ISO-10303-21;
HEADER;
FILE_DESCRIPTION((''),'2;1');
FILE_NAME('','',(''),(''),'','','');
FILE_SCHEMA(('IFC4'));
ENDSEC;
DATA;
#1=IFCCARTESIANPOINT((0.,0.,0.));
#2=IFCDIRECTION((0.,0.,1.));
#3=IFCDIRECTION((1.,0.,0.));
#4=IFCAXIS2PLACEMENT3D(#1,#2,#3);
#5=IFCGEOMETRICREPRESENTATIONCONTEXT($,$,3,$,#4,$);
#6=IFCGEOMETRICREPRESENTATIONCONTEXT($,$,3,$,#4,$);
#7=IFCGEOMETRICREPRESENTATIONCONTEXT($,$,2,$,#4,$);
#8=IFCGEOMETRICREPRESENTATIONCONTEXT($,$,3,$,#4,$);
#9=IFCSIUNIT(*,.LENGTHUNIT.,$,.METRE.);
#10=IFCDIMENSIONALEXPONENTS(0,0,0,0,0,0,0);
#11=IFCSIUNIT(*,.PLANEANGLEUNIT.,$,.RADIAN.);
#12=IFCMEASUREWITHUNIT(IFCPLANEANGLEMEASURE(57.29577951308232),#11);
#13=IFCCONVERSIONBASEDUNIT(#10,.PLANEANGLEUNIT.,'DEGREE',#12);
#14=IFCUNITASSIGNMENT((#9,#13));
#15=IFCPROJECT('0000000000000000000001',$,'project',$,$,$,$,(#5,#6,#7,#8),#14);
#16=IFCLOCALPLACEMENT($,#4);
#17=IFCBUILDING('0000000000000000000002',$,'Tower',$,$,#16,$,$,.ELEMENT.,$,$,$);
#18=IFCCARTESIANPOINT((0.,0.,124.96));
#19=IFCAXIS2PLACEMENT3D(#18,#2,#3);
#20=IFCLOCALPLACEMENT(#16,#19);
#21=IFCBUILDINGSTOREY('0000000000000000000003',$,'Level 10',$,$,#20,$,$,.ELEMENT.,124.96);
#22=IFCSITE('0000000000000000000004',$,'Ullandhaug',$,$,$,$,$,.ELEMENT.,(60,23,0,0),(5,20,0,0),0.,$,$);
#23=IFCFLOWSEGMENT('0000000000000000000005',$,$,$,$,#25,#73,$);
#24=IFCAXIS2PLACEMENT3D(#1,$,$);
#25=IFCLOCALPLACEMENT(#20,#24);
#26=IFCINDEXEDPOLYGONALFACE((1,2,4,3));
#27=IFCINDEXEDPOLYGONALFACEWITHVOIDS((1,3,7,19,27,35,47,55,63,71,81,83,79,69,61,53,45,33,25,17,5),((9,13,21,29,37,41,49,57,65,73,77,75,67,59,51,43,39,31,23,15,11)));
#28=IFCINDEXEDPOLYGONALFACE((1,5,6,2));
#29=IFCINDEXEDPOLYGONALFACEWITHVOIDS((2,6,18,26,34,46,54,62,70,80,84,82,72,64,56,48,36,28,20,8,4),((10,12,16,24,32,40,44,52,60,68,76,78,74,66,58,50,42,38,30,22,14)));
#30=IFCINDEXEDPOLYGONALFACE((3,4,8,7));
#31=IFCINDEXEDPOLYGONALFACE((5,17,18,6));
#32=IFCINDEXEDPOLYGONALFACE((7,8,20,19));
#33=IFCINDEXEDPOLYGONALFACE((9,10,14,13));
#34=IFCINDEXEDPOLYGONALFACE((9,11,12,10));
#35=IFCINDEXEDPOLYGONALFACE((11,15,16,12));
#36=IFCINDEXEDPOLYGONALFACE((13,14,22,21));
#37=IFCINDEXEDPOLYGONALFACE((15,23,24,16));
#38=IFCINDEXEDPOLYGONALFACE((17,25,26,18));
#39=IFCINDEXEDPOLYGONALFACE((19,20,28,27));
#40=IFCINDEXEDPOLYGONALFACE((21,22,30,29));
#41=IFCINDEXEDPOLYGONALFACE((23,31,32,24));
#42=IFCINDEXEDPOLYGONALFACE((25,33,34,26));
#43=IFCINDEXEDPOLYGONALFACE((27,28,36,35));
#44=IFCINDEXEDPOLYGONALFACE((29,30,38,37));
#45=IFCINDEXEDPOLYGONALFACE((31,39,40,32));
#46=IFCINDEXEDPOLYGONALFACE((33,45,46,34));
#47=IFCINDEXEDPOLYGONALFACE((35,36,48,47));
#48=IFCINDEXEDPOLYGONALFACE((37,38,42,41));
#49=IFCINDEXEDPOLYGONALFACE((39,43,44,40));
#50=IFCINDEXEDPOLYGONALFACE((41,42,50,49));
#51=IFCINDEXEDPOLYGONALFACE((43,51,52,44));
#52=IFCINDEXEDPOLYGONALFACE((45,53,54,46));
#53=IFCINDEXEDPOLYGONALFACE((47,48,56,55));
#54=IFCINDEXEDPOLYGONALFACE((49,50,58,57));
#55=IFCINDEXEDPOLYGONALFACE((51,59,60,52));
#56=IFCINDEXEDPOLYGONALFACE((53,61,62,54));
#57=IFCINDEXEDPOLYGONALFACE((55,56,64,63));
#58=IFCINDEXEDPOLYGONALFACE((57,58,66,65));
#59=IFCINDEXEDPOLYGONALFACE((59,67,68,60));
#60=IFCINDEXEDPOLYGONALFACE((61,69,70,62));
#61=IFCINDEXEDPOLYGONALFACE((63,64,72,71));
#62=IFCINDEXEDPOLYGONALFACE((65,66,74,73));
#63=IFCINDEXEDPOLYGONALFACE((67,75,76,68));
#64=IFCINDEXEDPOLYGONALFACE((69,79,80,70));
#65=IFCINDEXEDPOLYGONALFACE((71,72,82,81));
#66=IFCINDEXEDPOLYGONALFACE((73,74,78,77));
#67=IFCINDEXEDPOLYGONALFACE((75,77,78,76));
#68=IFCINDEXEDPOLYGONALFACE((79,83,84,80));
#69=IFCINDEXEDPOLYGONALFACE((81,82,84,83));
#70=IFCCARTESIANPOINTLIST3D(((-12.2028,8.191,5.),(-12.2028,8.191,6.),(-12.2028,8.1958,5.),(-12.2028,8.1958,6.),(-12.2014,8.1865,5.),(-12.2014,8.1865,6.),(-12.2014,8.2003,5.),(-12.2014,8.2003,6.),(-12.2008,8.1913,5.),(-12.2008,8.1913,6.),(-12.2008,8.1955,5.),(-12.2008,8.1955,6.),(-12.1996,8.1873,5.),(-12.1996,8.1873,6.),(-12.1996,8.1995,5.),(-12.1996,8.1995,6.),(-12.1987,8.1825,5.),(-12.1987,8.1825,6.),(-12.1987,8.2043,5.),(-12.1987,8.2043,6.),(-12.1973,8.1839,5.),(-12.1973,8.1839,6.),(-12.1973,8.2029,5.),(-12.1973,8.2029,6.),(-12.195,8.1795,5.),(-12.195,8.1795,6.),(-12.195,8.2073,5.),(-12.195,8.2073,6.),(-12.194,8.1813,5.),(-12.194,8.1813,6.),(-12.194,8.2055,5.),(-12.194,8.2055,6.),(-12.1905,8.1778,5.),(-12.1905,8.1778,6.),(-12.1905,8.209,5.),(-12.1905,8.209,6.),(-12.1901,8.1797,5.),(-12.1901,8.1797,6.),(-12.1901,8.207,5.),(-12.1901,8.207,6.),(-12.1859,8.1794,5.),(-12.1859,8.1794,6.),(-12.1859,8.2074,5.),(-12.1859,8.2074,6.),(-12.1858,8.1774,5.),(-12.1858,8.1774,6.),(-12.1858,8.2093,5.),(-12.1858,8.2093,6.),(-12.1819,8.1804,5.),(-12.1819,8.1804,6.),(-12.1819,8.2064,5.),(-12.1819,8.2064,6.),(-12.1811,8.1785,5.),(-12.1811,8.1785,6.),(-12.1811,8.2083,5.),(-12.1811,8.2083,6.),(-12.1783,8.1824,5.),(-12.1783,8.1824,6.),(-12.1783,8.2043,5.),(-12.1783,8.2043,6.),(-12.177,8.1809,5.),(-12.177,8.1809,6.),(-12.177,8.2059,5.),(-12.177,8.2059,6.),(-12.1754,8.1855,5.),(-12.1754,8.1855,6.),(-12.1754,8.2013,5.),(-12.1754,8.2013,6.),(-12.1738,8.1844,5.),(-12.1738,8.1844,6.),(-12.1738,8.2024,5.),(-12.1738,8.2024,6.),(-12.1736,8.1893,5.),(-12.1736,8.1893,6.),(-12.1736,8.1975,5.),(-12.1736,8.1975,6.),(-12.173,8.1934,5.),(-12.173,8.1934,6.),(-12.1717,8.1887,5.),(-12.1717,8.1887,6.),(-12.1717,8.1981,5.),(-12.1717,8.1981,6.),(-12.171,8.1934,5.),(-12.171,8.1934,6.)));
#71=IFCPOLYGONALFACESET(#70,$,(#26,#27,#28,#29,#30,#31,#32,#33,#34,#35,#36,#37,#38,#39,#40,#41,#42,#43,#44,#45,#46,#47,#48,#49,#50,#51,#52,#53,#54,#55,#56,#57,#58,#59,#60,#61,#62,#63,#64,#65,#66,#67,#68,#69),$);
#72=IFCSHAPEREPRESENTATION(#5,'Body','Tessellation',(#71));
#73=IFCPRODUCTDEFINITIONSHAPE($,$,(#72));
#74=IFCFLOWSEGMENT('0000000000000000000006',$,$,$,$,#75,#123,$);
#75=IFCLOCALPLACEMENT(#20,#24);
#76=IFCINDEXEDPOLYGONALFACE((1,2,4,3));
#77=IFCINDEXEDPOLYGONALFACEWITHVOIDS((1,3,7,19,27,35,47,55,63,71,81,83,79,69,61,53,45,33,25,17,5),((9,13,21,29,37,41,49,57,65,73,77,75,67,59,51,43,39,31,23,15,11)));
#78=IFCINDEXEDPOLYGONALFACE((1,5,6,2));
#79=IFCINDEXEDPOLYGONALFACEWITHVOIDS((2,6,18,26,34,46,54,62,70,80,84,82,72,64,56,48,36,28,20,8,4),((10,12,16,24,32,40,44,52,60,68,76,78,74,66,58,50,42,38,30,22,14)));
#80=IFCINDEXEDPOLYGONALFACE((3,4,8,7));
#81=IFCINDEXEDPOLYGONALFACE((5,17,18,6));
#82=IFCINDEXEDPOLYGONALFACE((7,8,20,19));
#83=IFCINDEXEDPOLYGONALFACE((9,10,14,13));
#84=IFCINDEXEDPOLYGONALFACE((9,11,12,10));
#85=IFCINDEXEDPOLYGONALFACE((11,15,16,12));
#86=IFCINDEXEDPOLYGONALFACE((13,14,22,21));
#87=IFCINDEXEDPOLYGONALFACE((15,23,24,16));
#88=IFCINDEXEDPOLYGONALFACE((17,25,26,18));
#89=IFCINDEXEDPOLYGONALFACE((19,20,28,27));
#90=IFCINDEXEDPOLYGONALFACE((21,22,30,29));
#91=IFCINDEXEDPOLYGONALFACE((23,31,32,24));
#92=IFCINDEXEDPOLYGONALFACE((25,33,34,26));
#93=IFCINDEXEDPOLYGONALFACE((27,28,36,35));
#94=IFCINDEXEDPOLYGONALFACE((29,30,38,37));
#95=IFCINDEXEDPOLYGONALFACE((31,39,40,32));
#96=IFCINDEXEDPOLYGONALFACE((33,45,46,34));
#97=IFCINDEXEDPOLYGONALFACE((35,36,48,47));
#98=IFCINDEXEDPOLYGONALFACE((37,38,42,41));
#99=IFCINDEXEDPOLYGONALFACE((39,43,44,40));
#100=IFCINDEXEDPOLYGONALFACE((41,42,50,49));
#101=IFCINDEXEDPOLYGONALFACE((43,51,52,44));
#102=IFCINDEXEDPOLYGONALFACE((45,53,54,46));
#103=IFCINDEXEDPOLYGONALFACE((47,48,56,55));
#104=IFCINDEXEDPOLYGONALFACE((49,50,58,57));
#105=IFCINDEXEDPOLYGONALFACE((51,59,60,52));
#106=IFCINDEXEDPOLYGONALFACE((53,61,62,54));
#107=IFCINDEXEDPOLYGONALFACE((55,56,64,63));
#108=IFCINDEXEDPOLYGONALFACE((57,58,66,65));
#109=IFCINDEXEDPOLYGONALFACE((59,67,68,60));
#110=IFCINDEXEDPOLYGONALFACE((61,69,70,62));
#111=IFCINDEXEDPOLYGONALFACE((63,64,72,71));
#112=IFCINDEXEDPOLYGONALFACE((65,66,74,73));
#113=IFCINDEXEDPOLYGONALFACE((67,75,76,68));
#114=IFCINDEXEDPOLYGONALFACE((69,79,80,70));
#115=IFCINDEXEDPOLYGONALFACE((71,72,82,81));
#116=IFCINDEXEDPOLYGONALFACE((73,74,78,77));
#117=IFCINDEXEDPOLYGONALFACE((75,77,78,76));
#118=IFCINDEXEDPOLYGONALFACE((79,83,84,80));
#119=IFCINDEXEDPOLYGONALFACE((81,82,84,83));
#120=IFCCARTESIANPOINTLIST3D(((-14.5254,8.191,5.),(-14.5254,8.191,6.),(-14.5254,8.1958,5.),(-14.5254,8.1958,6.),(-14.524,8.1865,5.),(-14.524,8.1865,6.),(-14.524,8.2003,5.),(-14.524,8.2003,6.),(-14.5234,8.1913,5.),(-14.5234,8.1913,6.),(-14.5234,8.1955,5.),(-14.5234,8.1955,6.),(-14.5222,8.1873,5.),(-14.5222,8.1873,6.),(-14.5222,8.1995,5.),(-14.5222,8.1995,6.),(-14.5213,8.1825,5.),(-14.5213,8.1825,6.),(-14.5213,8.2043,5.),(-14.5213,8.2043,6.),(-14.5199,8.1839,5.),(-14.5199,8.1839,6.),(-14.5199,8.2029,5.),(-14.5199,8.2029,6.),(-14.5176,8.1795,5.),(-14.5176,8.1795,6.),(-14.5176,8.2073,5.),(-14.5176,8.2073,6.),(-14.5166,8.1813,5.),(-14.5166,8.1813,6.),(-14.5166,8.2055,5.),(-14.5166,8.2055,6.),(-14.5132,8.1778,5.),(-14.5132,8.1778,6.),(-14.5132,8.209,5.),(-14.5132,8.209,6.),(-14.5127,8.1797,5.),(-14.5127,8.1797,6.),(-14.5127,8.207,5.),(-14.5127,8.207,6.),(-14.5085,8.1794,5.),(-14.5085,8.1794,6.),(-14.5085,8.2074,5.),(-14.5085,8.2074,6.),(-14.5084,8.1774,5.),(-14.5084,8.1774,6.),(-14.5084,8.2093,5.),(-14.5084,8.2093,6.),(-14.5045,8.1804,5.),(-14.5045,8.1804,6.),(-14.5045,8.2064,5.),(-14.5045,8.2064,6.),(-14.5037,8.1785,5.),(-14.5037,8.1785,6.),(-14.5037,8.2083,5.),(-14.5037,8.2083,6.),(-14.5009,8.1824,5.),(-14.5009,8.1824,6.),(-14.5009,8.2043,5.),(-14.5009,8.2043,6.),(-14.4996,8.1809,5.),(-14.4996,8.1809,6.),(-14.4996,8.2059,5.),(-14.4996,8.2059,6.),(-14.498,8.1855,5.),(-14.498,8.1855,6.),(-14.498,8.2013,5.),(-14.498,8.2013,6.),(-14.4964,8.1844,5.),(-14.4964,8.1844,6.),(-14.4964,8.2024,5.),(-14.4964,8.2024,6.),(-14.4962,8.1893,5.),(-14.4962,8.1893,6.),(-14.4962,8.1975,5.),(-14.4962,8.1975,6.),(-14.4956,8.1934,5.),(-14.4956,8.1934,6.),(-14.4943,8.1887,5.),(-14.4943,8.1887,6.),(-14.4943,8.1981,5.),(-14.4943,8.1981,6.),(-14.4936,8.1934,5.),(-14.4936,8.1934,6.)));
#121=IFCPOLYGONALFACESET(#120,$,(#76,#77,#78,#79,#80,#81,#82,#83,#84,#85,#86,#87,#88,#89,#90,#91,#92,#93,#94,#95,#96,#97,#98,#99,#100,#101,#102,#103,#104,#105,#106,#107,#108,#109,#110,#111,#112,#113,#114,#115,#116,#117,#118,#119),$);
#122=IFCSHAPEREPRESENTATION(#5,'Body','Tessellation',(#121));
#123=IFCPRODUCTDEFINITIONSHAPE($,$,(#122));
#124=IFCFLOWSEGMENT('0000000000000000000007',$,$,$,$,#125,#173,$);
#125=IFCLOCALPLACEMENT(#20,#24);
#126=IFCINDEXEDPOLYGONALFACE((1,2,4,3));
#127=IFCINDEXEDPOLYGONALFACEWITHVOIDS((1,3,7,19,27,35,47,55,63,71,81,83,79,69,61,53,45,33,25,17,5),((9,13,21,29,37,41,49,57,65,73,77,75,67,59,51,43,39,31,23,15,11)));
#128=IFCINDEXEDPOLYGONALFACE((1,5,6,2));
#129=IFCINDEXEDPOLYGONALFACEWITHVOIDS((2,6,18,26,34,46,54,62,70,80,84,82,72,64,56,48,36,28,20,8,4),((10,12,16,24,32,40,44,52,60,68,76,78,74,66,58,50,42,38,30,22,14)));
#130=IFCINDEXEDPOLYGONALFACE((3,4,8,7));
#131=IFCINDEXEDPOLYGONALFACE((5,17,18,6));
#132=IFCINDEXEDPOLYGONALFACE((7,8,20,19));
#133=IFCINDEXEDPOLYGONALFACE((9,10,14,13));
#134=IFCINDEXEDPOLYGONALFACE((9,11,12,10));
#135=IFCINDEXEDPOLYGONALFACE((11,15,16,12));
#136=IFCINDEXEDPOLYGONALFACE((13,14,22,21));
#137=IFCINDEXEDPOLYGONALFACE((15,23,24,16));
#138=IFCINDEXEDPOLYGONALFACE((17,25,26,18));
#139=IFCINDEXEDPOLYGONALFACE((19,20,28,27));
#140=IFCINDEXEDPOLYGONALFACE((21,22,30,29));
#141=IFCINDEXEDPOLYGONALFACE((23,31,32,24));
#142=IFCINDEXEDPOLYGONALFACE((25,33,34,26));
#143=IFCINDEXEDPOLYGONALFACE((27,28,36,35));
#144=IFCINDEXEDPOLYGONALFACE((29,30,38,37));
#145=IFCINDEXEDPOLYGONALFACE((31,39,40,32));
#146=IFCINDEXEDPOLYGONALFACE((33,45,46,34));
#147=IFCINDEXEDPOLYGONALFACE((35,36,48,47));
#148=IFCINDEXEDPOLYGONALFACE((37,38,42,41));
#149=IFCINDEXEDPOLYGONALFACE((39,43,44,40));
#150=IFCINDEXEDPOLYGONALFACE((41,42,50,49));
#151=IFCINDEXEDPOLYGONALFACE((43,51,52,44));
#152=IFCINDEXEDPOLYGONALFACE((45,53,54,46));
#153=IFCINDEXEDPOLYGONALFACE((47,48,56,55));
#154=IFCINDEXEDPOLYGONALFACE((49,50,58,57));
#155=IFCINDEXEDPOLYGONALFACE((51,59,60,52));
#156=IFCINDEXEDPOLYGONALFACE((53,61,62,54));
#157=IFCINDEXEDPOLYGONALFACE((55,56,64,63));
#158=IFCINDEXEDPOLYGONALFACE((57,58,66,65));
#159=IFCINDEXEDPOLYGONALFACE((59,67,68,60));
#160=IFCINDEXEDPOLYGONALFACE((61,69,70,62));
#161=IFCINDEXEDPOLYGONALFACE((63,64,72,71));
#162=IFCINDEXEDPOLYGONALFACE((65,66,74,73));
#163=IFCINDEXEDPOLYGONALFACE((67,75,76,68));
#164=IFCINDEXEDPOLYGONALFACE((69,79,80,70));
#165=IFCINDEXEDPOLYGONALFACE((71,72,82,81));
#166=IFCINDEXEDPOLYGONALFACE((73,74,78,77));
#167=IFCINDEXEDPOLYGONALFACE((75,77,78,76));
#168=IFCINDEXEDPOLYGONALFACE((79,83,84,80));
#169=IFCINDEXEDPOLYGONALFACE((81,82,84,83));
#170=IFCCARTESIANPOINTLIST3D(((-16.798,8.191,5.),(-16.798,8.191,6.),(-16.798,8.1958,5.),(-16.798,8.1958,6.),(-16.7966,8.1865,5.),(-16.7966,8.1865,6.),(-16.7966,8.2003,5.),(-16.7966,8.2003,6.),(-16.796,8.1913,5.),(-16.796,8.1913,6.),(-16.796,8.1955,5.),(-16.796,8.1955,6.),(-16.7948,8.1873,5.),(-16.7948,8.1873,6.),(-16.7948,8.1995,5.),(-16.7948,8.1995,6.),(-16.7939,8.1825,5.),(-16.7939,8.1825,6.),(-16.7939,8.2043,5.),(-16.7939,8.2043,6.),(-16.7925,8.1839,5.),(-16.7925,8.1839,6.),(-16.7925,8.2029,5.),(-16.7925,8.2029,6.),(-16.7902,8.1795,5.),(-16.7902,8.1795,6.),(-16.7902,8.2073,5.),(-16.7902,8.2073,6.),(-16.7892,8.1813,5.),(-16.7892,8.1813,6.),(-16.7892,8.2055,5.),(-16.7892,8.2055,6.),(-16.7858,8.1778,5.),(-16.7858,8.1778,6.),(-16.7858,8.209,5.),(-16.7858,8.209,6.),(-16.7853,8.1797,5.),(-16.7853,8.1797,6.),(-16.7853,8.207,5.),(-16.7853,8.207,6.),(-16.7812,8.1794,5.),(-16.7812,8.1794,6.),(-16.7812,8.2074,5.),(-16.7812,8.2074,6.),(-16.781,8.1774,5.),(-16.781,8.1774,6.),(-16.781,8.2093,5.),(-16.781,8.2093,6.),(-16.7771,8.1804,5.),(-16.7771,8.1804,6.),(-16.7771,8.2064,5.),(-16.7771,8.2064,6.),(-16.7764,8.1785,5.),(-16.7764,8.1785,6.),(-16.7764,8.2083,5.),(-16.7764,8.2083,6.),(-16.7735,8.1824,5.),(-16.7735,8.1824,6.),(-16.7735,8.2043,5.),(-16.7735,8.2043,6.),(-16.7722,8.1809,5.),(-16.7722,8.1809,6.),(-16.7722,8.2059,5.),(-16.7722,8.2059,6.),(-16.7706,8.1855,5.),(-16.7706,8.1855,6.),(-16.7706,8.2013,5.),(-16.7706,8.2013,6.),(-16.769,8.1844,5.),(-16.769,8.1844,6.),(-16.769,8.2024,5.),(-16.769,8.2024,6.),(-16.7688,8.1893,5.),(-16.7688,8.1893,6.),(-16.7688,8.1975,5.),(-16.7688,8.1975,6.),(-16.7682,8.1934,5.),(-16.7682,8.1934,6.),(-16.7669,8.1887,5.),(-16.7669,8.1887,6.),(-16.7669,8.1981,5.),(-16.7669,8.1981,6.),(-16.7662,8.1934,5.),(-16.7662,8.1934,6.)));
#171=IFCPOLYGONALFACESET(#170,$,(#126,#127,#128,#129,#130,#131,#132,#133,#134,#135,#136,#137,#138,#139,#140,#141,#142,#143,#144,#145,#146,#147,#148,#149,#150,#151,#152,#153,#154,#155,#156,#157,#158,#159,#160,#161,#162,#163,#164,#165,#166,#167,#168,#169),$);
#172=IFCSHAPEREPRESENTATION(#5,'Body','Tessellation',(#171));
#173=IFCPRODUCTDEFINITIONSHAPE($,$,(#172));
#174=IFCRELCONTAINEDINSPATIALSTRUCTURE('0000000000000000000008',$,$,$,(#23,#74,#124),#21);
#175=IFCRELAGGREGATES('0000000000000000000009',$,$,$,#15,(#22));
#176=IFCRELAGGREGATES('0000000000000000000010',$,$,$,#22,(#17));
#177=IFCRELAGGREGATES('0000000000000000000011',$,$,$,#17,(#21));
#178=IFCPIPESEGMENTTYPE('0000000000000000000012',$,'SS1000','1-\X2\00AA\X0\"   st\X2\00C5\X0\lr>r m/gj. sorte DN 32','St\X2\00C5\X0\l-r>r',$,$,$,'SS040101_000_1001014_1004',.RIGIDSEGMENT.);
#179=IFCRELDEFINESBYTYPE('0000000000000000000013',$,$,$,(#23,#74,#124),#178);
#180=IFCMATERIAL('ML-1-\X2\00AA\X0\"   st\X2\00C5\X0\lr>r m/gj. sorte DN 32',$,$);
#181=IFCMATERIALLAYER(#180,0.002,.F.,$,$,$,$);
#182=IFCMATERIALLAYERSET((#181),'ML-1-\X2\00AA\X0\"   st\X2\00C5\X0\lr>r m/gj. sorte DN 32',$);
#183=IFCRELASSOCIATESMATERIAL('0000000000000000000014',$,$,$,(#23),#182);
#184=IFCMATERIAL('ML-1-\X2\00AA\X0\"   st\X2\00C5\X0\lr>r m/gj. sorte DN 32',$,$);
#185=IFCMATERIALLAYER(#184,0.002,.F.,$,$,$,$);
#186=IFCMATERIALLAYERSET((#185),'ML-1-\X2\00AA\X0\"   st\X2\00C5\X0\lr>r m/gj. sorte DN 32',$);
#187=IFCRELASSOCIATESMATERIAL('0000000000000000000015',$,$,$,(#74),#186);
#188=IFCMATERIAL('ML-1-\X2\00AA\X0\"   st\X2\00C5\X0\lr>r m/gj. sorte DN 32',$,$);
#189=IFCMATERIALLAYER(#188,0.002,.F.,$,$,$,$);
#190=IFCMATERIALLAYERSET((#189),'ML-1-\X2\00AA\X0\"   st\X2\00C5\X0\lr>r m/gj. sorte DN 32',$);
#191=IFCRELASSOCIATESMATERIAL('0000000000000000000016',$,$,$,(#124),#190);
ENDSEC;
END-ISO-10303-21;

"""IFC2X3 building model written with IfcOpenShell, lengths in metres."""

from ifc_helpers import new_model, entity, si_unit, converted_unit, frame, origin_with_axes, origin_2d_with_axis, place, context, project, spatial, hollow_circle, extrude, material, layer, layer_set, layer_usage, type_object, element, save


model = new_model("IFC2X3")

# Units and contexts
context_of_model_1 = context(None, 3, world=origin_with_axes())
context_of_model_2 = context(None, 3, world=origin_with_axes())
context_of_model_3 = context(None, 2, world=origin_with_axes())
context_of_model_4 = context(None, 3, world=origin_with_axes())
ifc_project = project(units=[si_unit("LENGTHUNIT", "METRE"), converted_unit("PLANEANGLEUNIT", "DEGREE", entity("IfcPlaneAngleMeasure", 57.29577951308232), si_unit("PLANEANGLEUNIT", "RADIAN"), dimensions=[0, 0, 0, 0, 0, 0, 0])], contexts=[context_of_model_1, context_of_model_2, context_of_model_3, context_of_model_4])

# Site, building, storey
site = spatial("IfcSite", under=ifc_project, Name="Ullandhaug", CompositionType="ELEMENT", RefLatitude=(60, 23, 0, 0), RefLongitude=(5, 20, 0, 0), RefElevation=0.0)
building_placement = place(None, origin_with_axes())
building = spatial("IfcBuilding", under=site, at=building_placement, Name="Tower", CompositionType="ELEMENT")
storey_placement = place(building_placement, frame((0.0, 0.0, 124.96), z_axis=(0.0, 0.0, 1.0), x_axis=(1.0, 0.0, 0.0)))
storey = spatial("IfcBuildingStorey", under=building, at=storey_placement, Name="Level 10", CompositionType="ELEMENT", Elevation=124.96)

# Flow segments
ifc_material_1 = material(Name="ML-1-ª\"   stÅlr>r m/gj. sorte DN 32")
ifc_layer_1 = layer(ifc_material_1, 0.002, ventilated=False)
ifc_layer_set_1 = layer_set([ifc_layer_1], Name="ML-1-ª\"   stÅlr>r m/gj. sorte DN 32")
ifc_layer_usage_1 = layer_usage(ifc_layer_set_1, "AXIS2", "POSITIVE", 0.0)
pipe_segment_type_1 = type_object("IfcPipeSegmentType", Name="SS1000", Description="1-ª\"   stÅlr>r m/gj. sorte DN 32", ApplicableOccurrence="StÅl-r>r", ElementType="SS040101_000_1001014_1004", PredefinedType="RIGIDSEGMENT")
flow_segment_1_placement = place(storey_placement, frame((-12.187, 8.1934, 5.0), z_axis=(0.0, 0.0, 1.0), x_axis=(1.0, 0.0, 0.0)))
element("IfcFlowSegment", 1, at=flow_segment_1_placement, inside=storey, type_object=pipe_segment_type_1, material=ifc_layer_usage_1, context=context_of_model_1, shape_type="SweptSolid", body=[
    extrude(hollow_circle(Radius=0.016, WallThickness=0.002, at=origin_2d_with_axis()), origin_with_axes(), (0.0, 0.0, 1.0), 1.0),
])
ifc_material_2 = material(Name="ML-1-ª\"   stÅlr>r m/gj. sorte DN 32")
ifc_layer_2 = layer(ifc_material_2, 0.002, ventilated=False)
ifc_layer_set_2 = layer_set([ifc_layer_2], Name="ML-1-ª\"   stÅlr>r m/gj. sorte DN 32")
ifc_layer_usage_2 = layer_usage(ifc_layer_set_2, "AXIS2", "POSITIVE", 0.0)
flow_segment_2_placement = place(storey_placement, frame((-14.5096, 8.1934, 5.0), z_axis=(0.0, 0.0, 1.0), x_axis=(1.0, 0.0, 0.0)))
element("IfcFlowSegment", 2, at=flow_segment_2_placement, inside=storey, type_object=pipe_segment_type_1, material=ifc_layer_usage_2, context=context_of_model_1, shape_type="SweptSolid", body=[
    extrude(hollow_circle(Radius=0.016, WallThickness=0.002, at=origin_2d_with_axis()), origin_with_axes(), (0.0, 0.0, 1.0), 1.0),
])
ifc_material_3 = material(Name="ML-1-ª\"   stÅlr>r m/gj. sorte DN 32")
ifc_layer_3 = layer(ifc_material_3, 0.002, ventilated=False)
ifc_layer_set_3 = layer_set([ifc_layer_3], Name="ML-1-ª\"   stÅlr>r m/gj. sorte DN 32")
ifc_layer_usage_3 = layer_usage(ifc_layer_set_3, "AXIS2", "POSITIVE", 0.0)
flow_segment_3_placement = place(storey_placement, frame((-16.7822, 8.1934, 5.0), z_axis=(0.0, 0.0, 1.0), x_axis=(1.0, 0.0, 0.0)))
element("IfcFlowSegment", 3, at=flow_segment_3_placement, inside=storey, type_object=pipe_segment_type_1, material=ifc_layer_usage_3, context=context_of_model_1, shape_type="SweptSolid", body=[
    extrude(hollow_circle(Radius=0.016, WallThickness=0.002, at=origin_2d_with_axis()), origin_with_axes(), (0.0, 0.0, 1.0), 1.0),
])

save(model, "model.ifc")
